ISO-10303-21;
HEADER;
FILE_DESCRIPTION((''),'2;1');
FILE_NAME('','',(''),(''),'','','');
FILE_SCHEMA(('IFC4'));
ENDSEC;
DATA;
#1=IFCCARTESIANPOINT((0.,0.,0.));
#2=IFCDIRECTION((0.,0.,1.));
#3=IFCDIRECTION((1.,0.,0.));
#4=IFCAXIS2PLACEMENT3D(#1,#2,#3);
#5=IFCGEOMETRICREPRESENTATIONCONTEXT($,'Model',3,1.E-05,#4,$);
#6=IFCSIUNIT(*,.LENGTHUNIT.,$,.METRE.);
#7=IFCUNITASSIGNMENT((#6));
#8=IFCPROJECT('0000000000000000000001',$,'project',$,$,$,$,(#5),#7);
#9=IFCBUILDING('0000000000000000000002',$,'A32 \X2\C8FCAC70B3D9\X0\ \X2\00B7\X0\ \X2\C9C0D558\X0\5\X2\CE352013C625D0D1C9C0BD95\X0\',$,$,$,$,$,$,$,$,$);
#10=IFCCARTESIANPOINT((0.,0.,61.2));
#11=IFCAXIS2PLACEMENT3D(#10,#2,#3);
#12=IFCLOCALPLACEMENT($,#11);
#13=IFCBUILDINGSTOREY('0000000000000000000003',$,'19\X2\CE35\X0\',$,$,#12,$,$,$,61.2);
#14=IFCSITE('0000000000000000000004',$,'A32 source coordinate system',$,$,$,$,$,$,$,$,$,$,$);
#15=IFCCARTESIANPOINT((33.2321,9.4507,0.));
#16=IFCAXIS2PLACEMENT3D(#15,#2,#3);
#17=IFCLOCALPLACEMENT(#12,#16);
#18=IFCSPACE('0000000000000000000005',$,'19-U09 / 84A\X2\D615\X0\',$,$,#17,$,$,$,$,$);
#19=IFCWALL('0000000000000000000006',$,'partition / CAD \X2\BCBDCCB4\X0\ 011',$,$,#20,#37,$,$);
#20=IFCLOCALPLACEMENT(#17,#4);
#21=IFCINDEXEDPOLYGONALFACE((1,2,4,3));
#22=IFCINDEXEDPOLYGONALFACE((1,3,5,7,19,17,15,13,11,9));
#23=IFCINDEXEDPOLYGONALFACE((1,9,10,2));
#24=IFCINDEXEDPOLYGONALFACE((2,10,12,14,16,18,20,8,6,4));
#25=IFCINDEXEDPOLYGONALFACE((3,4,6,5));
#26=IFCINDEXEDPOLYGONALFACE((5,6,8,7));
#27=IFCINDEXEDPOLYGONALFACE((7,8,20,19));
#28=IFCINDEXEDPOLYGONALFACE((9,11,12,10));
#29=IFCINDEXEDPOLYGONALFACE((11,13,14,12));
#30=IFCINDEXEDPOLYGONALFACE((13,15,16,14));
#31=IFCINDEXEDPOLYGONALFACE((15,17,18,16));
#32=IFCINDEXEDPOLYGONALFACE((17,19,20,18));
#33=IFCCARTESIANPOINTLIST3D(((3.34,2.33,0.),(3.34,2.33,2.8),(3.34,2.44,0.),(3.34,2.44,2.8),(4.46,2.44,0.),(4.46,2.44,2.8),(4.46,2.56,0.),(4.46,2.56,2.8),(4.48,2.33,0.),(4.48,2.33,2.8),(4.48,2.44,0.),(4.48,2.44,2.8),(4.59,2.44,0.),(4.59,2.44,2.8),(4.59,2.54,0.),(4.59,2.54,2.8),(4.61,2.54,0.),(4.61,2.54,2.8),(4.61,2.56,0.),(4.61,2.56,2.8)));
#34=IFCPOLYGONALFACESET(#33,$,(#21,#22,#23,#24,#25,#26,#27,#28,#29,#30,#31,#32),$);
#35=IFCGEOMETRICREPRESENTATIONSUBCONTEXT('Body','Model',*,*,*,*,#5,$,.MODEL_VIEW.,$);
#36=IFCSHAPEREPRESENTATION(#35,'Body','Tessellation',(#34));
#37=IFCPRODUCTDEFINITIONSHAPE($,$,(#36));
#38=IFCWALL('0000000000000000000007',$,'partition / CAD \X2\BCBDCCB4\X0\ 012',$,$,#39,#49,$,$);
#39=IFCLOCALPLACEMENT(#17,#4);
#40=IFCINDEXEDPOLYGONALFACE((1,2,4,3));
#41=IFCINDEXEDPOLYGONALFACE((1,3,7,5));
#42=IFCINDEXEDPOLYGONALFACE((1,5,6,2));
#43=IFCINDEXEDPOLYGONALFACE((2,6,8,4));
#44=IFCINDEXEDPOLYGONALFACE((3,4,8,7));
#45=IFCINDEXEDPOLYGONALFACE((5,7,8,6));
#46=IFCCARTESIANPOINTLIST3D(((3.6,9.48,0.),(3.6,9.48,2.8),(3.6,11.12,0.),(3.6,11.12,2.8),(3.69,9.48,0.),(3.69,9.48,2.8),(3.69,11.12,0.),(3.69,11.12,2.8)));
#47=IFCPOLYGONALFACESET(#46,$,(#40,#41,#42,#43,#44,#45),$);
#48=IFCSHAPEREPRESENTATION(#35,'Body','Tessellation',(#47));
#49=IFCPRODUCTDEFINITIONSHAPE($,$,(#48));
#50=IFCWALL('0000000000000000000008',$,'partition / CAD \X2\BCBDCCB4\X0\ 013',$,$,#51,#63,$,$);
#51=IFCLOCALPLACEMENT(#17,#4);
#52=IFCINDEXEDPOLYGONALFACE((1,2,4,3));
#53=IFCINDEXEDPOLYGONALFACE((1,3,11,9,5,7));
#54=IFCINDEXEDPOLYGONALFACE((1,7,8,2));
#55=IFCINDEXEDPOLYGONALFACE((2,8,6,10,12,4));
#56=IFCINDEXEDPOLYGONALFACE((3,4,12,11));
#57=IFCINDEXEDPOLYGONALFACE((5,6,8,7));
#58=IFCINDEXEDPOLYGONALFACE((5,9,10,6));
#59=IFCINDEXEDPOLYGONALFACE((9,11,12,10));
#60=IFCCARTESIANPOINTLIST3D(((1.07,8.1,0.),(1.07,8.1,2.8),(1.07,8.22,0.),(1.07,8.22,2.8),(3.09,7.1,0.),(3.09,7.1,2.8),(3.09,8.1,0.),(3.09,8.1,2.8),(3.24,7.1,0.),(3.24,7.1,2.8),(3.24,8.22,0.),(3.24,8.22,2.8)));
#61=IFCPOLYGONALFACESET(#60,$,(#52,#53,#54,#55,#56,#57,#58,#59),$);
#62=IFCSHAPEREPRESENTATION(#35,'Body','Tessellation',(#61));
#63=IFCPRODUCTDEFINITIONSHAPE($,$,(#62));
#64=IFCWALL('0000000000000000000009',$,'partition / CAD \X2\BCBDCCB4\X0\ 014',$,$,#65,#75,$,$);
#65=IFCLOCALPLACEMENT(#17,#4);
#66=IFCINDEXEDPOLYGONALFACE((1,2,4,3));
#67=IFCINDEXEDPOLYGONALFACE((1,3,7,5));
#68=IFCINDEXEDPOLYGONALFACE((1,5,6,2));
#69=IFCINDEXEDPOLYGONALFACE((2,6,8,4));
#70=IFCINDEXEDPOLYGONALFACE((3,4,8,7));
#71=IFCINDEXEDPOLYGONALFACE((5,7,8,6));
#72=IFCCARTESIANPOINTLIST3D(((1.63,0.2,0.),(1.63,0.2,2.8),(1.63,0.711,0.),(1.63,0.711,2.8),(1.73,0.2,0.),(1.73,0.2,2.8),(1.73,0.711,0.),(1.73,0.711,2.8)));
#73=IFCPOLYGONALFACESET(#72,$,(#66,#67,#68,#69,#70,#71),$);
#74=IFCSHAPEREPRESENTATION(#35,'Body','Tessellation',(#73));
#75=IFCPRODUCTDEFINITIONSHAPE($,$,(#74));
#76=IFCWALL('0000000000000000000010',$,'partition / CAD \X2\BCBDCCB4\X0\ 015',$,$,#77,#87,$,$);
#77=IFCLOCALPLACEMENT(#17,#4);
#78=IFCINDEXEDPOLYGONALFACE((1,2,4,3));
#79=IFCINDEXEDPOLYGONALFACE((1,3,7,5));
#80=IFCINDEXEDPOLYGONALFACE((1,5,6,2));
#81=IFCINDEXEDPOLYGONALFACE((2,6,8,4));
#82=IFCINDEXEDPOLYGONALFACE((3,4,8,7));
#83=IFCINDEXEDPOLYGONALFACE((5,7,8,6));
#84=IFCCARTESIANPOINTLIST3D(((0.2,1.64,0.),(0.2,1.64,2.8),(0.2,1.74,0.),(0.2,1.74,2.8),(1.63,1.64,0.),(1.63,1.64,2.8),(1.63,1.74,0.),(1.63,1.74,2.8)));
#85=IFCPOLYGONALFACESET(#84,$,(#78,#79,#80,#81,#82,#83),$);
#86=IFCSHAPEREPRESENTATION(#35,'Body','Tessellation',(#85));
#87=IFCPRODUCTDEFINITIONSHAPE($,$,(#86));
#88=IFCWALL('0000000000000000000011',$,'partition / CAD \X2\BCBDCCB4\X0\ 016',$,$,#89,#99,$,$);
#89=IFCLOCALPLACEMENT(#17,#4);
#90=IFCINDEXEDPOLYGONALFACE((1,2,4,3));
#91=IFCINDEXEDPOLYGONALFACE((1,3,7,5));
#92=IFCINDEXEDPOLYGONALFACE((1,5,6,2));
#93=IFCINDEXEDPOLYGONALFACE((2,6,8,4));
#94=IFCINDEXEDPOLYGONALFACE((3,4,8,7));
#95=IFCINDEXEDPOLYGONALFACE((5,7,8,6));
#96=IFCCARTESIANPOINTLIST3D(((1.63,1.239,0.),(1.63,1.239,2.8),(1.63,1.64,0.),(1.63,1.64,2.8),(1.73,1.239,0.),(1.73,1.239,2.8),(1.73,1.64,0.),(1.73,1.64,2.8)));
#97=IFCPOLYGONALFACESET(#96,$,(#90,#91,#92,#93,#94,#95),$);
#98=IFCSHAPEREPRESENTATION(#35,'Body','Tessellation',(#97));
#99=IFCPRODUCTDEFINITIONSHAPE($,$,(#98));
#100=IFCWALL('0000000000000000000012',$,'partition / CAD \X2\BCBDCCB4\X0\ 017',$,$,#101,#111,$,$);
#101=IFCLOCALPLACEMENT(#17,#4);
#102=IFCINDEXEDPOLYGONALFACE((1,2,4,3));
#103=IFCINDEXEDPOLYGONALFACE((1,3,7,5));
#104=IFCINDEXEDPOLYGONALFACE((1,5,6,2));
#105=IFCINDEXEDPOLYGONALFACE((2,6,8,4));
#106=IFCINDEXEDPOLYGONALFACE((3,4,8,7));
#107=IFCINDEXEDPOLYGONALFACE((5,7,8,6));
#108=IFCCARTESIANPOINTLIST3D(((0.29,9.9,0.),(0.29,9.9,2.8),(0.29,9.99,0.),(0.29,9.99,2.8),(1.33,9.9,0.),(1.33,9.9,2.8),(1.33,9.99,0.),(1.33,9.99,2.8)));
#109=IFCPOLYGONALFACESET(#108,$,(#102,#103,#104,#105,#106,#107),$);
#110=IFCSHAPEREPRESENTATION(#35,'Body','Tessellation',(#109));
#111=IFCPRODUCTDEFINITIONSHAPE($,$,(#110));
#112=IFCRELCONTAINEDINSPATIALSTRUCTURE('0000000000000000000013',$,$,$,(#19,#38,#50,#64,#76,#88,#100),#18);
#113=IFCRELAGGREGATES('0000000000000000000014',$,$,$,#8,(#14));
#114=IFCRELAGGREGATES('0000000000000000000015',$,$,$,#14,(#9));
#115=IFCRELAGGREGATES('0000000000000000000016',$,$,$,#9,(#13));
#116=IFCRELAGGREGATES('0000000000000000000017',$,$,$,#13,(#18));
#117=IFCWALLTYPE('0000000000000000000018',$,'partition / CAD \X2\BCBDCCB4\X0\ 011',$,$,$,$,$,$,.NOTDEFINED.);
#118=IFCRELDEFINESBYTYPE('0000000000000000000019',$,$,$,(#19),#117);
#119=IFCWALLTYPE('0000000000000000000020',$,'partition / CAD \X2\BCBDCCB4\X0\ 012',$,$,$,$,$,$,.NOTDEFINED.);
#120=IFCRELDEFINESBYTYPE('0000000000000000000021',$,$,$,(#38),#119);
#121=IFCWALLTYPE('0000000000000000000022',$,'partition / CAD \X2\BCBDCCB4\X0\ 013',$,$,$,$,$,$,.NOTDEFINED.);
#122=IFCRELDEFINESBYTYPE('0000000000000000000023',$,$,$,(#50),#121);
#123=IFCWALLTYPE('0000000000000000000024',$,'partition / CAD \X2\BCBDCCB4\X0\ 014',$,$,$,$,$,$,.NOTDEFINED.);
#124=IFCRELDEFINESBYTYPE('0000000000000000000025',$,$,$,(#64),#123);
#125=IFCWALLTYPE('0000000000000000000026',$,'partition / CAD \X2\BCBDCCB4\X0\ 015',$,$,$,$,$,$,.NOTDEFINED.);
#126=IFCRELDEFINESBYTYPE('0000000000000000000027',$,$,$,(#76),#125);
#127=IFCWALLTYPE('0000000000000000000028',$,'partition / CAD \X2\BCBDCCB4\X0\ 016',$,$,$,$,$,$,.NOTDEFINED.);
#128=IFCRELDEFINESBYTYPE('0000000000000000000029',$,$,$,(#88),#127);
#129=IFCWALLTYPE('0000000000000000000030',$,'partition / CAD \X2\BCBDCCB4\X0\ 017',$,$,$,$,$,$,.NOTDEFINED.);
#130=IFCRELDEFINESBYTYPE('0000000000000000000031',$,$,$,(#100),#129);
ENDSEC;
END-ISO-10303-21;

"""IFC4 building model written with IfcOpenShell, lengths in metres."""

from ifc_helpers import new_model, si_unit, frame, origin, origin_with_axes, place, context, subcontext, project, spatial, polyline, outline, extrude, source, transform, mapped, type_object, type_shapes, element, save


model = new_model("IFC4")

# Units and contexts
model_context = context("Model", 3, precision=1e-05, world=origin_with_axes())
body_context = subcontext(model_context, "Body", "Model", "MODEL_VIEW")
ifc_project = project(units=[si_unit("LENGTHUNIT", "METRE")], contexts=[model_context])

# Site, building, storey, space
storey_placement = place(None, frame((0.0, 0.0, 61.2), z_axis=(0.0, 0.0, 1.0), x_axis=(1.0, 0.0, 0.0)))
space_placement = place(storey_placement, frame((33.2321, 9.4507, 0.0), z_axis=(0.0, 0.0, 1.0), x_axis=(1.0, 0.0, 0.0)))
site = spatial("IfcSite", under=ifc_project, Name="A32 source coordinate system")
building = spatial("IfcBuilding", under=site, Name="A32 주거동 · 지하5층–옥탑지붕")
storey = spatial("IfcBuildingStorey", under=building, at=storey_placement, Name="19층", Elevation=61.2)
space = spatial("IfcSpace", under=storey, at=space_placement, Name="19-U09 / 84A형")

# Walls
wall_type_1 = type_object("IfcWallType", Name="partition / CAD 벽체 011", PredefinedType="NOTDEFINED")
shared_shape_1 = source(origin(), body_context, "Body", "SweptSolid", [
    extrude(outline(polyline([(3.34, 2.33), (3.34, 2.44), (4.46, 2.44), (4.46, 2.56), (4.61, 2.56), (4.61, 2.54), (4.59, 2.54), (4.59, 2.44), (4.48, 2.44), (4.48, 2.33), (3.34, 2.33)])), origin(), (0.0, 0.0, 1.0), 2.8),
])
type_shapes(wall_type_1, [shared_shape_1])
wall_1_placement = place(space_placement, origin_with_axes())
element("IfcWall", 1, at=wall_1_placement, inside=space, type_object=wall_type_1, Name="partition / CAD 벽체 011", context=body_context, shape_type="MappedRepresentation", body=[
    mapped(shared_shape_1, transform((0.0, 0.0, 0.0), scale=1.0)),
])
wall_type_2 = type_object("IfcWallType", Name="partition / CAD 벽체 012", PredefinedType="NOTDEFINED")
shared_shape_2 = source(origin(), body_context, "Body", "SweptSolid", [
    extrude(outline(polyline([(3.6, 11.12), (3.69, 11.12), (3.69, 9.48), (3.6, 9.48), (3.6, 11.12)])), origin(), (0.0, 0.0, 1.0), 2.8),
])
type_shapes(wall_type_2, [shared_shape_2])
wall_2_placement = place(space_placement, origin_with_axes())
element("IfcWall", 2, at=wall_2_placement, inside=space, type_object=wall_type_2, Name="partition / CAD 벽체 012", context=body_context, shape_type="MappedRepresentation", body=[
    mapped(shared_shape_2, transform((0.0, 0.0, 0.0), scale=1.0)),
])
wall_type_3 = type_object("IfcWallType", Name="partition / CAD 벽체 013", PredefinedType="NOTDEFINED")
shared_shape_3 = source(origin(), body_context, "Body", "SweptSolid", [
    extrude(outline(polyline([(3.09, 8.1), (1.07, 8.1), (1.07, 8.22), (3.24, 8.22), (3.24, 7.1), (3.09, 7.1), (3.09, 8.1)])), origin(), (0.0, 0.0, 1.0), 2.8),
])
type_shapes(wall_type_3, [shared_shape_3])
wall_3_placement = place(space_placement, origin_with_axes())
element("IfcWall", 3, at=wall_3_placement, inside=space, type_object=wall_type_3, Name="partition / CAD 벽체 013", context=body_context, shape_type="MappedRepresentation", body=[
    mapped(shared_shape_3, transform((0.0, 0.0, 0.0), scale=1.0)),
])
wall_type_4 = type_object("IfcWallType", Name="partition / CAD 벽체 014", PredefinedType="NOTDEFINED")
shared_shape_4 = source(origin(), body_context, "Body", "SweptSolid", [
    extrude(outline(polyline([(1.73, 0.2), (1.63, 0.2), (1.63, 0.711), (1.73, 0.711), (1.73, 0.2)])), origin(), (0.0, 0.0, 1.0), 2.8),
])
type_shapes(wall_type_4, [shared_shape_4])
wall_4_placement = place(space_placement, origin_with_axes())
element("IfcWall", 4, at=wall_4_placement, inside=space, type_object=wall_type_4, Name="partition / CAD 벽체 014", context=body_context, shape_type="MappedRepresentation", body=[
    mapped(shared_shape_4, transform((0.0, 0.0, 0.0), scale=1.0)),
])
wall_type_5 = type_object("IfcWallType", Name="partition / CAD 벽체 015", PredefinedType="NOTDEFINED")
shared_shape_5 = source(origin(), body_context, "Body", "SweptSolid", [
    extrude(outline(polyline([(1.63, 1.74), (1.63, 1.64), (0.2, 1.64), (0.2, 1.74), (1.63, 1.74)])), origin(), (0.0, 0.0, 1.0), 2.8),
])
type_shapes(wall_type_5, [shared_shape_5])
wall_5_placement = place(space_placement, origin_with_axes())
element("IfcWall", 5, at=wall_5_placement, inside=space, type_object=wall_type_5, Name="partition / CAD 벽체 015", context=body_context, shape_type="MappedRepresentation", body=[
    mapped(shared_shape_5, transform((0.0, 0.0, 0.0), scale=1.0)),
])
wall_type_6 = type_object("IfcWallType", Name="partition / CAD 벽체 016", PredefinedType="NOTDEFINED")
shared_shape_6 = source(origin(), body_context, "Body", "SweptSolid", [
    extrude(outline(polyline([(1.73, 1.239), (1.63, 1.239), (1.63, 1.64), (1.73, 1.64), (1.73, 1.239)])), origin(), (0.0, 0.0, 1.0), 2.8),
])
type_shapes(wall_type_6, [shared_shape_6])
wall_6_placement = place(space_placement, origin_with_axes())
element("IfcWall", 6, at=wall_6_placement, inside=space, type_object=wall_type_6, Name="partition / CAD 벽체 016", context=body_context, shape_type="MappedRepresentation", body=[
    mapped(shared_shape_6, transform((0.0, 0.0, 0.0), scale=1.0)),
])
wall_type_7 = type_object("IfcWallType", Name="partition / CAD 벽체 017", PredefinedType="NOTDEFINED")
shared_shape_7 = source(origin(), body_context, "Body", "SweptSolid", [
    extrude(outline(polyline([(1.33, 9.99), (1.33, 9.9), (0.29, 9.9), (0.29, 9.99), (1.33, 9.99)])), origin(), (0.0, 0.0, 1.0), 2.8),
])
type_shapes(wall_type_7, [shared_shape_7])
wall_7_placement = place(space_placement, origin_with_axes())
element("IfcWall", 7, at=wall_7_placement, inside=space, type_object=wall_type_7, Name="partition / CAD 벽체 017", context=body_context, shape_type="MappedRepresentation", body=[
    mapped(shared_shape_7, transform((0.0, 0.0, 0.0), scale=1.0)),
])

save(model, "model.ifc")
